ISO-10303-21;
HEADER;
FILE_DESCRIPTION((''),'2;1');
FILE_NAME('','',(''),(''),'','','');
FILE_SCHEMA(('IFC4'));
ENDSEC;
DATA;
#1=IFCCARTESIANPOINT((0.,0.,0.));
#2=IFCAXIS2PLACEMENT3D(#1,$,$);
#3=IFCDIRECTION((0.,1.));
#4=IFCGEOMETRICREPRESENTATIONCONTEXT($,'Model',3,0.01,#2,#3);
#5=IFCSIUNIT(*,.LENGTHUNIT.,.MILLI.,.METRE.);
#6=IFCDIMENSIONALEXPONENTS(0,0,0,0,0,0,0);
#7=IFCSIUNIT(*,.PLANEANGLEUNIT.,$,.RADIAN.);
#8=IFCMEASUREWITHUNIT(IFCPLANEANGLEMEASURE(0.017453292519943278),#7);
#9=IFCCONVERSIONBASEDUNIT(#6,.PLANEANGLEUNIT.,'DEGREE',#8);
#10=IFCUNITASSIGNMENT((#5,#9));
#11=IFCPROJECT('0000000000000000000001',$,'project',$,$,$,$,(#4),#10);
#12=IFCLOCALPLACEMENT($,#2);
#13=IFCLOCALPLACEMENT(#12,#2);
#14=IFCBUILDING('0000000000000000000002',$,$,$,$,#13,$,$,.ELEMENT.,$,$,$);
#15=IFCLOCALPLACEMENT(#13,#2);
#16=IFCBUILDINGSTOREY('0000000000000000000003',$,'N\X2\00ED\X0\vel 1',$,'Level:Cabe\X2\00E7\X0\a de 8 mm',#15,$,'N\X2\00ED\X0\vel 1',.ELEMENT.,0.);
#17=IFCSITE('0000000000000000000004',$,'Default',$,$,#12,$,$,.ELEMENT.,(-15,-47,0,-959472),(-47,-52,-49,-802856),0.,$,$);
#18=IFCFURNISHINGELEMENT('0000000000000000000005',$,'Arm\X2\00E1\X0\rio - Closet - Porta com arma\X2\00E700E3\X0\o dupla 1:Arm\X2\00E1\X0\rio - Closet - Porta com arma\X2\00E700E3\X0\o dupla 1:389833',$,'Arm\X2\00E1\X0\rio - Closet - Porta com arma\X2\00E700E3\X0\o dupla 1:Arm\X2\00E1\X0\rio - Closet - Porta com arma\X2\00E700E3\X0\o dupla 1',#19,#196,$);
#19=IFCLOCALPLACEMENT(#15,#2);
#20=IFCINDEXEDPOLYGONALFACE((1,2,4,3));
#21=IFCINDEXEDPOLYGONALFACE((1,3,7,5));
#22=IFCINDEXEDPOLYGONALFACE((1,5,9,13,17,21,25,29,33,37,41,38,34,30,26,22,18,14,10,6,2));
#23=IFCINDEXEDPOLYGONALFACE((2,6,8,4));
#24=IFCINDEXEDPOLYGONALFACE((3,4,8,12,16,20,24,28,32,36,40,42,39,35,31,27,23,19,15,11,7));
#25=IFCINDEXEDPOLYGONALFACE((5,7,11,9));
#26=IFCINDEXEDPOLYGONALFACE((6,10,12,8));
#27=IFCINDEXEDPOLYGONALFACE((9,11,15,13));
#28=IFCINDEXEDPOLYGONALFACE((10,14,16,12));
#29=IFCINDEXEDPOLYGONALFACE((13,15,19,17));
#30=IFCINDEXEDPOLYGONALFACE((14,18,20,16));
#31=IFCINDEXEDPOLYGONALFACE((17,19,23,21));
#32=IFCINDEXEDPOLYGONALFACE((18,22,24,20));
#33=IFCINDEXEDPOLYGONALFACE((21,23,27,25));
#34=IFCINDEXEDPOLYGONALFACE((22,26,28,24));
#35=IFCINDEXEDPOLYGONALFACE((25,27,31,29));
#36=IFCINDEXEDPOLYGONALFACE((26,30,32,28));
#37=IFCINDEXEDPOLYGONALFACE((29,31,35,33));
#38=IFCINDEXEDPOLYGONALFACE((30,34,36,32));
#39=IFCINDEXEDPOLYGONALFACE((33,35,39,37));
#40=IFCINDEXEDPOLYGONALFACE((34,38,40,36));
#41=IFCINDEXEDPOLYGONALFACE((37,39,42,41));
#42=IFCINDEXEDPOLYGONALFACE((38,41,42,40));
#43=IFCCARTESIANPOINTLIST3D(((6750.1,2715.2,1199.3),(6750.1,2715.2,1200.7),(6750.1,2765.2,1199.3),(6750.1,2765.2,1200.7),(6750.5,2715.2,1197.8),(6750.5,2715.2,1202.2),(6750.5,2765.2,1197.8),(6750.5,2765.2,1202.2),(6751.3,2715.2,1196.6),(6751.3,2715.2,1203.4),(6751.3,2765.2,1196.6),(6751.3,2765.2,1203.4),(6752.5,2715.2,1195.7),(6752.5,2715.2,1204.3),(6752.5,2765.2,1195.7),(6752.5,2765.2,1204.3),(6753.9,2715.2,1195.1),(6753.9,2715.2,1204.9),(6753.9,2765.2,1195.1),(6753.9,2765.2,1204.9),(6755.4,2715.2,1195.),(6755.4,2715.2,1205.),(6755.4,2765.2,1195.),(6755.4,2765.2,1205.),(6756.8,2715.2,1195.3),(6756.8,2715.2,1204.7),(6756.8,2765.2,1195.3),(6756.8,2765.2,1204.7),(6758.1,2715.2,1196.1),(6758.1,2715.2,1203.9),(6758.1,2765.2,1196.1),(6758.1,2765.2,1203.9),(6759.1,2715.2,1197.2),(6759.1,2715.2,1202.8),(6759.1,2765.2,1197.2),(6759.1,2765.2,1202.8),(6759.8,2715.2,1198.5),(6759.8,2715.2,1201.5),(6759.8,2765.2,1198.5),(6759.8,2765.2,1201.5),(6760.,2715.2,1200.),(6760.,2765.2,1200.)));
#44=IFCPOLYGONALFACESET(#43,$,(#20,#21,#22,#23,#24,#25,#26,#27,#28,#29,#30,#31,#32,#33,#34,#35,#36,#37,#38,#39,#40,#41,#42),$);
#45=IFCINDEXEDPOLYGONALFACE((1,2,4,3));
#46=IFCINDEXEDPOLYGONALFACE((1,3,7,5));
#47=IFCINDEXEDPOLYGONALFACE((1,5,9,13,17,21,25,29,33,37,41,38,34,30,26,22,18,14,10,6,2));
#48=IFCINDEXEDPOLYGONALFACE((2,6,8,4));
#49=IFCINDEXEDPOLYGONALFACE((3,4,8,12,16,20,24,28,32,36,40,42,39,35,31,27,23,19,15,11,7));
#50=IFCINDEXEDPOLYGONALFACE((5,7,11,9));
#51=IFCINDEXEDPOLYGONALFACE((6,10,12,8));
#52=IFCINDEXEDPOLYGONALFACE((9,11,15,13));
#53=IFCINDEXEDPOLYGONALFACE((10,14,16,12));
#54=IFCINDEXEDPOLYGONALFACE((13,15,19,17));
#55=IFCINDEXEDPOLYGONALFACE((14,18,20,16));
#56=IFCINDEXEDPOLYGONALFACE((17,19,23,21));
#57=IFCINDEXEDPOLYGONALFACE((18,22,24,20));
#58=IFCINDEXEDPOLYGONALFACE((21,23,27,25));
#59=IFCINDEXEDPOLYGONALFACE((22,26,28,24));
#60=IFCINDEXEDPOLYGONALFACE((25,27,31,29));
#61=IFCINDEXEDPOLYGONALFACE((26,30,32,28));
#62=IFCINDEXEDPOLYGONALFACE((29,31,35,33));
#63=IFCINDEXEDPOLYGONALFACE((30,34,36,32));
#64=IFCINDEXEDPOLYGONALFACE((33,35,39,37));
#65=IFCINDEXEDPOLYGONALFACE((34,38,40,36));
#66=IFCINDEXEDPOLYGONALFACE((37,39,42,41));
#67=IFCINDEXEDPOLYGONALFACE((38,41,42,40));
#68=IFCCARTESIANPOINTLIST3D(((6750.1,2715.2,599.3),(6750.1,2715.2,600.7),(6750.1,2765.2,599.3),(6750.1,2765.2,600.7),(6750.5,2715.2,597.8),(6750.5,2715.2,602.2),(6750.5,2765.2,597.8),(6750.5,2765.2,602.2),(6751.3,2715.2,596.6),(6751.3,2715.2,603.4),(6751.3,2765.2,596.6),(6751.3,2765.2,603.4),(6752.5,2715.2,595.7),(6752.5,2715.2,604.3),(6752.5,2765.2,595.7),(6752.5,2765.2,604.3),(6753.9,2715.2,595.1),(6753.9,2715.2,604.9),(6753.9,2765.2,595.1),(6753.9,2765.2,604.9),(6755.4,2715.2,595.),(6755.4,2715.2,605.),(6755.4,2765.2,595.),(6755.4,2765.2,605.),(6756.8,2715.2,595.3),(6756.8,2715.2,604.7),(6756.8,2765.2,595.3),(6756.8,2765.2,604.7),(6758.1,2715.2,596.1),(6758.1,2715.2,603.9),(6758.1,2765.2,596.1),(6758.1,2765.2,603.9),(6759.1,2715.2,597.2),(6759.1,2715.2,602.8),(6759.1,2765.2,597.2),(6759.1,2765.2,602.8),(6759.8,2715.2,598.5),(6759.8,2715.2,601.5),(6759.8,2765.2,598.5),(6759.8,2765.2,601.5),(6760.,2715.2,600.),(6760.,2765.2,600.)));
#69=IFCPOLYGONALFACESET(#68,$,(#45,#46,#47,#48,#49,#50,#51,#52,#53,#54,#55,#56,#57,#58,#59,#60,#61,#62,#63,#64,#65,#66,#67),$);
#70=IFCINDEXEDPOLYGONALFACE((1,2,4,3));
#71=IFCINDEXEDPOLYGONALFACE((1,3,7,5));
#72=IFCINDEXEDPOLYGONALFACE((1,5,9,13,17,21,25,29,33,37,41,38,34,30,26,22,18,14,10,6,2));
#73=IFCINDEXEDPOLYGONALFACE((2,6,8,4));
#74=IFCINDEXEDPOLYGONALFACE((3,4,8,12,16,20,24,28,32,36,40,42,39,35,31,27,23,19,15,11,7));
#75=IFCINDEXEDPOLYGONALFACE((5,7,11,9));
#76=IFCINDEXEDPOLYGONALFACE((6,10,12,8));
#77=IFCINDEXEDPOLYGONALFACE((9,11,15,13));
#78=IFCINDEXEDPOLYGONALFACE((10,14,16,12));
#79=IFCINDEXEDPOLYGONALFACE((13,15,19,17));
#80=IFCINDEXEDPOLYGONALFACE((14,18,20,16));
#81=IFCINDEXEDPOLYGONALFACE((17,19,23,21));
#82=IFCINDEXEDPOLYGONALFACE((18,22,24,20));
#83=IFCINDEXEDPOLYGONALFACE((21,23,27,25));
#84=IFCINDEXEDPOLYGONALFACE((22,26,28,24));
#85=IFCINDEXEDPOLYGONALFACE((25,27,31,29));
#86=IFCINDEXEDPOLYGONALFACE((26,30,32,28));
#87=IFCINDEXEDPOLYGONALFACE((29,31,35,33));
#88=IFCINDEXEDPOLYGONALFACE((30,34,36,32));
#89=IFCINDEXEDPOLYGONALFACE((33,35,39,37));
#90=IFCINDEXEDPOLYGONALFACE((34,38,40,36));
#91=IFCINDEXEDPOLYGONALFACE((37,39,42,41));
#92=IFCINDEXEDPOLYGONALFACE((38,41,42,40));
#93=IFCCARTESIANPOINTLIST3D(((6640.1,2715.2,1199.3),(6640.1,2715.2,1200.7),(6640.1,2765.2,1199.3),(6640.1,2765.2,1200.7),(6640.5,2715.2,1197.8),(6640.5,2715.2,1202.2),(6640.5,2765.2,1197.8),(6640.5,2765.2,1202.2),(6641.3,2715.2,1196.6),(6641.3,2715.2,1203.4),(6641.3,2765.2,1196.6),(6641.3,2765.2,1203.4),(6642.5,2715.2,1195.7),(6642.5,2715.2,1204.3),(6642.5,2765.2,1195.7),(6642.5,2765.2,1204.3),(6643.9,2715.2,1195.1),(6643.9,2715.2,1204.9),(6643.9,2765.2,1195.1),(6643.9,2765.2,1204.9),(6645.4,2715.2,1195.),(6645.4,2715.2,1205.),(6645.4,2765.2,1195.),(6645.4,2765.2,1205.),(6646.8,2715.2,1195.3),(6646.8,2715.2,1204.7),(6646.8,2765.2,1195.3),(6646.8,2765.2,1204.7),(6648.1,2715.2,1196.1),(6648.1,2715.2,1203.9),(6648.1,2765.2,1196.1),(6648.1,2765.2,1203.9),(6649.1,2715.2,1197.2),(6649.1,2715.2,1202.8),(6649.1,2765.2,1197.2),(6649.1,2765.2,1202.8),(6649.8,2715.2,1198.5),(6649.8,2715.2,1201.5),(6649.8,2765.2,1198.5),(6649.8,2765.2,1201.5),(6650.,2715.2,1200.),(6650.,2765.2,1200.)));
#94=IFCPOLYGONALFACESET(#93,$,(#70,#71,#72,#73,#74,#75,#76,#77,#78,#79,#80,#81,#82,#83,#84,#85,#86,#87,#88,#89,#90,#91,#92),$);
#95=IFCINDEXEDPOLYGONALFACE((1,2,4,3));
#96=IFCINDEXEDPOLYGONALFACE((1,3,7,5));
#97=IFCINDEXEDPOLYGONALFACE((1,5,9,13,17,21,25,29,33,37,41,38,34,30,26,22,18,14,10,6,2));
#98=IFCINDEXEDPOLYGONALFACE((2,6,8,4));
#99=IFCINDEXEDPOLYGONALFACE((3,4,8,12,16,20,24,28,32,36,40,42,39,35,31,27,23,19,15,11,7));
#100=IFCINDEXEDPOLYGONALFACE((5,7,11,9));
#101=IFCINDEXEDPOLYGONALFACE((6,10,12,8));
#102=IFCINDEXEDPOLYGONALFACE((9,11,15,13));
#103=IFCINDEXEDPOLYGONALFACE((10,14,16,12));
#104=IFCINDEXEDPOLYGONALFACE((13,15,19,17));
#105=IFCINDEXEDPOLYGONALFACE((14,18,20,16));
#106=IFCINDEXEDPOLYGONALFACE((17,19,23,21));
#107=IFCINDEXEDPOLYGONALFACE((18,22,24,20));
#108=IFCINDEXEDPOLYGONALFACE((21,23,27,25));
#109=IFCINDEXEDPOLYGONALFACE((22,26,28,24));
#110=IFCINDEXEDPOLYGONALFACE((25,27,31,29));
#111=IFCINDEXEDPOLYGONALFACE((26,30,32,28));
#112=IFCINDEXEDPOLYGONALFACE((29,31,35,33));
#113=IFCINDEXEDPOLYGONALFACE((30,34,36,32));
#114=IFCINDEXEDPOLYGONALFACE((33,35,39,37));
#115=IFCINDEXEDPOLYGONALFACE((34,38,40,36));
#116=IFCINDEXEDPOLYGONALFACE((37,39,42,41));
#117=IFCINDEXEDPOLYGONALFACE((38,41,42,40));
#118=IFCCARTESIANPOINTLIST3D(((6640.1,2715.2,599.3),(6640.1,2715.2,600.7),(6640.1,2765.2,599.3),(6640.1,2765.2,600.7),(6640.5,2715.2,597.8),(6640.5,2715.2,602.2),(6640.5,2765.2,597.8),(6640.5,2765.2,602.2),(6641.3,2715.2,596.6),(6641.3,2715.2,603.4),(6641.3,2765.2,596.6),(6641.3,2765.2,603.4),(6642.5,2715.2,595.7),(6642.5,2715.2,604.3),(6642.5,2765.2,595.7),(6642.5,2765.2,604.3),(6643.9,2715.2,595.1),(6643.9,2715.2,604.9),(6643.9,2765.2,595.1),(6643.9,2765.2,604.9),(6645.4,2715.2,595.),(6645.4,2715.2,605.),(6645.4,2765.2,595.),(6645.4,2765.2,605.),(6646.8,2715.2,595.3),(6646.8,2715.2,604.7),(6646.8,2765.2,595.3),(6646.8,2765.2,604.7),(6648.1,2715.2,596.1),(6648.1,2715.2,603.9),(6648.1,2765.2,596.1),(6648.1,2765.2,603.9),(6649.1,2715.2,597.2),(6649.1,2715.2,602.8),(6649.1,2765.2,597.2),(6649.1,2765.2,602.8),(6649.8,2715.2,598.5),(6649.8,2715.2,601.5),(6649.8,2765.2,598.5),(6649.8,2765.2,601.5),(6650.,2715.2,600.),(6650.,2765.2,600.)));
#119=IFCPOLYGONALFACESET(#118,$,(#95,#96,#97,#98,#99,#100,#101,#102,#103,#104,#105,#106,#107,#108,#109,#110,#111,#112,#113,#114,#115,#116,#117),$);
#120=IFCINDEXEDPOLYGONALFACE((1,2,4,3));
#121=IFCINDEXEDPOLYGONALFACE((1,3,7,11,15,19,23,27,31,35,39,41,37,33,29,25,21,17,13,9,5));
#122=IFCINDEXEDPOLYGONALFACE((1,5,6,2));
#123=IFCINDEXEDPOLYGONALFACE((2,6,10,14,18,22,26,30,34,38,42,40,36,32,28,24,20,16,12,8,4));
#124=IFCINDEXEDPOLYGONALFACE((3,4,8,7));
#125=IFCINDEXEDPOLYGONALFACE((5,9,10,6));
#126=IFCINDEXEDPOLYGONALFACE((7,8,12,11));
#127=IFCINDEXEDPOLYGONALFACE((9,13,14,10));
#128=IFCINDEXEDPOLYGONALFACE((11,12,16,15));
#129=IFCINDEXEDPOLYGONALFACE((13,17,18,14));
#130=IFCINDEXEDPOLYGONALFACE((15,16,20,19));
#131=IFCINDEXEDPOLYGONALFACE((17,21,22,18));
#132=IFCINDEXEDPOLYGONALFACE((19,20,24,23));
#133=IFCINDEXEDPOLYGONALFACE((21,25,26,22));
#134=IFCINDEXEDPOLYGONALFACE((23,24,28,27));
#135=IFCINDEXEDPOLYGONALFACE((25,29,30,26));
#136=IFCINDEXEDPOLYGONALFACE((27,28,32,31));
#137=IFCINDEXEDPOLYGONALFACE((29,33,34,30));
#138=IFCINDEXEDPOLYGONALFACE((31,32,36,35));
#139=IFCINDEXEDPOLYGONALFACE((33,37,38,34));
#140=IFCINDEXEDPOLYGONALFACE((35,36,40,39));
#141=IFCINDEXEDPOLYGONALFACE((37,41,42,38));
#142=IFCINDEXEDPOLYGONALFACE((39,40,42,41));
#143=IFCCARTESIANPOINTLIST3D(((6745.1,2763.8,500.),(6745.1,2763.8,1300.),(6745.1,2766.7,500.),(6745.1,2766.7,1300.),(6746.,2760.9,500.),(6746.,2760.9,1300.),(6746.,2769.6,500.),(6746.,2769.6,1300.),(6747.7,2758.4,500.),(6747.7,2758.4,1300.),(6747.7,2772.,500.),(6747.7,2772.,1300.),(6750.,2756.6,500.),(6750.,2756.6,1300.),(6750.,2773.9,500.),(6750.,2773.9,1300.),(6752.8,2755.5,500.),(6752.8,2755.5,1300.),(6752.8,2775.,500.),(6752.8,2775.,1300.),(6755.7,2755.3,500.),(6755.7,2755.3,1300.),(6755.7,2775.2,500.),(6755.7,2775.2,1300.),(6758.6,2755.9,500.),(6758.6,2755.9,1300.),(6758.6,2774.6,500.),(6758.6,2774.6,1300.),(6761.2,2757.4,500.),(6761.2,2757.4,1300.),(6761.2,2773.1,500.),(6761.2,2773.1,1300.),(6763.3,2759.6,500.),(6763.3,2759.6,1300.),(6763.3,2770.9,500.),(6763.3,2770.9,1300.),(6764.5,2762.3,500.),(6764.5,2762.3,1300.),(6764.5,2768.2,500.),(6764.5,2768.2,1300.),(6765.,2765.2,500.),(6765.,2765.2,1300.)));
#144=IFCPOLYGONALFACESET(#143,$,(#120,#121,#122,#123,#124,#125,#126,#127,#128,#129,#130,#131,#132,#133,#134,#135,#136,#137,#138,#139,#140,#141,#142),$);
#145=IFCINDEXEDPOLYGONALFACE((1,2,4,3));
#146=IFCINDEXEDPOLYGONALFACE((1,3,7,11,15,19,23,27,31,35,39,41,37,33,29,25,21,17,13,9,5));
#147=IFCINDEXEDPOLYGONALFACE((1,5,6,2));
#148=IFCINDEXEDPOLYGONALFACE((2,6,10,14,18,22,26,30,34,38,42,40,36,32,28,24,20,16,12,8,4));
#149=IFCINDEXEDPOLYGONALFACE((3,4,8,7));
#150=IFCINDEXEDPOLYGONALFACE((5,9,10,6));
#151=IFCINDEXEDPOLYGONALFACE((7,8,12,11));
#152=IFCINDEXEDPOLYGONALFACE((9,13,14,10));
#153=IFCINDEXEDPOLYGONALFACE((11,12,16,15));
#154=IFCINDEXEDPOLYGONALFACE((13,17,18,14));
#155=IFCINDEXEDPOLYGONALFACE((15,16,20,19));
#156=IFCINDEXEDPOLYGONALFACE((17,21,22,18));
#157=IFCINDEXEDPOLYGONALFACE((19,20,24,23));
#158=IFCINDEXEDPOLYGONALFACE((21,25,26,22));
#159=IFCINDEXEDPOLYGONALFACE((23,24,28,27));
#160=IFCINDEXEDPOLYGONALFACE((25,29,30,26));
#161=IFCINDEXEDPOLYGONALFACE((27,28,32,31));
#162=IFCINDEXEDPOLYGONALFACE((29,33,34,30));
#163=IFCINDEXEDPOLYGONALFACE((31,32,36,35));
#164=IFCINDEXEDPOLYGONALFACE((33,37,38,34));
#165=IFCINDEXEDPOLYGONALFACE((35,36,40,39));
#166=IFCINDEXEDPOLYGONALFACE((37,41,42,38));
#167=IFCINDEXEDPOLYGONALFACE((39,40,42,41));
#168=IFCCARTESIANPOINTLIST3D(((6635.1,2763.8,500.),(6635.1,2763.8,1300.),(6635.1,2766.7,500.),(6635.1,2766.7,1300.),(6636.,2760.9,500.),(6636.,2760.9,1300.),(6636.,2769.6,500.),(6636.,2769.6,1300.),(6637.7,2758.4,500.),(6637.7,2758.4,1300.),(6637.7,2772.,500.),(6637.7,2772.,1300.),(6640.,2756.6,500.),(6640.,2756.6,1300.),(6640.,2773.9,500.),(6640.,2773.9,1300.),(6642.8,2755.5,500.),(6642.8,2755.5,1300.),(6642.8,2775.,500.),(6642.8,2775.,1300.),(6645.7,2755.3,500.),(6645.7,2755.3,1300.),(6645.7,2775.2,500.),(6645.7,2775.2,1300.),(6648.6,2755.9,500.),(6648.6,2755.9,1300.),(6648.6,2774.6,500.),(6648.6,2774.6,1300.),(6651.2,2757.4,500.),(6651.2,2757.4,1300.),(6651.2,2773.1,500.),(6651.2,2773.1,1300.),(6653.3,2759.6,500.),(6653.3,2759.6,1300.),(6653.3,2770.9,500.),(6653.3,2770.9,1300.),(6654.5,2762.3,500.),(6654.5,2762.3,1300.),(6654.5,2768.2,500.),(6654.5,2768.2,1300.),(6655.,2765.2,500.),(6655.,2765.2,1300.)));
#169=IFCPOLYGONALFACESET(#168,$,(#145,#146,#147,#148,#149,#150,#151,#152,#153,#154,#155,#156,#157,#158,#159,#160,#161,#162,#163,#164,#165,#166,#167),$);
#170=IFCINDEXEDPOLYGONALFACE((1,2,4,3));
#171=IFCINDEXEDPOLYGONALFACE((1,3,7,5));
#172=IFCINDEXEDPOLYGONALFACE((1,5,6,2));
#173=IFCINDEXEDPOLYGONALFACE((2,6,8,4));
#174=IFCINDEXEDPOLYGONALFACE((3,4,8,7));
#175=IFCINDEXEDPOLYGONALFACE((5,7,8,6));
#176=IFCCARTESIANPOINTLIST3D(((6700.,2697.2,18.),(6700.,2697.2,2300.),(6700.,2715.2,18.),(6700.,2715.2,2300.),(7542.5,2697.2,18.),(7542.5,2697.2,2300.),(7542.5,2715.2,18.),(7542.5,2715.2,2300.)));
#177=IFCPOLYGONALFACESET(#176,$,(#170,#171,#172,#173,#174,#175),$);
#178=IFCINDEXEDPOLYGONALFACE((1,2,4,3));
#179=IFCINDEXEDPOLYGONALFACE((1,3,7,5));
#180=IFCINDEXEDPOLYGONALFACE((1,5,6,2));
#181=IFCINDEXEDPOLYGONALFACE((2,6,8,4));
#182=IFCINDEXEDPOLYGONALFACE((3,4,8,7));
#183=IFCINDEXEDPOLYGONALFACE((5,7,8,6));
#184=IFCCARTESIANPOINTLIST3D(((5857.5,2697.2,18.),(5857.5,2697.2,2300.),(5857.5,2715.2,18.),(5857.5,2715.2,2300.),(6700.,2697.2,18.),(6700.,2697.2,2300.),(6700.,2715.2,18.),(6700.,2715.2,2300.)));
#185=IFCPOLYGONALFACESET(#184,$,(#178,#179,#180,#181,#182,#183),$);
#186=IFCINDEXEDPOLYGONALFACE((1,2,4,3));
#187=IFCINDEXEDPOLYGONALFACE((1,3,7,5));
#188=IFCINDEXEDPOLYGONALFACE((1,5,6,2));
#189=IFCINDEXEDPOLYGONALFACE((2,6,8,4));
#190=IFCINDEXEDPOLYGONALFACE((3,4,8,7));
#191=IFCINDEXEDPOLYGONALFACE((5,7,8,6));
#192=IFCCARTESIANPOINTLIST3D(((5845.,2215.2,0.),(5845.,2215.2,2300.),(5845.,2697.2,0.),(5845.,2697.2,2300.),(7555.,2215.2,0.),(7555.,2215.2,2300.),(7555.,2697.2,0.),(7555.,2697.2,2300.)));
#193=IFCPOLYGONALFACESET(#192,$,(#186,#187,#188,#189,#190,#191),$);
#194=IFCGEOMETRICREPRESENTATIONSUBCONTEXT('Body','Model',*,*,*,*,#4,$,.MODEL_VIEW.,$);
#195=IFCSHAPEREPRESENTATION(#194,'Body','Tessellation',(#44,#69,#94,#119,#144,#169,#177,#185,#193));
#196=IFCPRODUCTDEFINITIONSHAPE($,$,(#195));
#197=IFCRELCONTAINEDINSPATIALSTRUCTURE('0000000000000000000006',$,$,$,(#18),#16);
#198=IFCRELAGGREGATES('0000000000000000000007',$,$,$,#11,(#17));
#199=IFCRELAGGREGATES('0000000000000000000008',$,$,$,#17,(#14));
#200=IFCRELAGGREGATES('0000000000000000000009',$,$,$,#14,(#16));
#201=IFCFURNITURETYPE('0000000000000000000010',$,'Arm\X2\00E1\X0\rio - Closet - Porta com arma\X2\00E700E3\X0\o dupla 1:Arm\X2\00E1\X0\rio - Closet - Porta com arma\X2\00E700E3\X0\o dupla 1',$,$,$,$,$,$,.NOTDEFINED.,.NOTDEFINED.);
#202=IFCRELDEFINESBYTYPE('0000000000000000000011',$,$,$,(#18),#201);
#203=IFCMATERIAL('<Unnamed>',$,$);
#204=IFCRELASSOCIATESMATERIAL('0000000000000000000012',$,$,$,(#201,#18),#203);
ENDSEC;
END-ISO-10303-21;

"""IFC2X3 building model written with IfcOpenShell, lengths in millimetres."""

from ifc_helpers import new_model, entity, si_unit, converted_unit, direction, frame, origin, origin_2d_with_axis, place, context, subcontext, project, spatial, rectangle, circle, extrude, source, transform, mapped, material, type_object, type_shapes, element, save


model = new_model("IFC2X3")

# Units and contexts
model_context = context("Model", 3, precision=0.01, world=origin(), true_north=direction((0.0, 1.0)))
body_context = subcontext(model_context, "Body", "Model", "MODEL_VIEW")
ifc_project = project(units=[si_unit("LENGTHUNIT", "METRE", prefix="MILLI"), converted_unit("PLANEANGLEUNIT", "DEGREE", entity("IfcPlaneAngleMeasure", 0.017453292519943278), si_unit("PLANEANGLEUNIT", "RADIAN"), dimensions=[0, 0, 0, 0, 0, 0, 0])], contexts=[model_context])

# Site, building, storey
site_placement = place(None, origin())
site = spatial("IfcSite", under=ifc_project, at=site_placement, Name="Default", CompositionType="ELEMENT", RefLatitude=(-15, -47, 0, -959472), RefLongitude=(-47, -52, -49, -802856), RefElevation=0.0)
building_placement = place(site_placement, origin())
building = spatial("IfcBuilding", under=site, at=building_placement, CompositionType="ELEMENT")
storey_placement = place(building_placement, origin())
storey = spatial("IfcBuildingStorey", under=building, at=storey_placement, Name="Nível 1", ObjectType="Level:Cabeça de 8 mm", LongName="Nível 1", CompositionType="ELEMENT", Elevation=0.0)

# Furnishing element
ifc_material_1 = material(Name="<Unnamed>")
furniture_type_1 = type_object("IfcFurnitureType", Name="Armário - Closet - Porta com armação dupla 1:Armário - Closet - Porta com armação dupla 1", AssemblyPlace="NOTDEFINED", material=ifc_material_1)
shared_shape_1 = source(origin(), body_context, "Body", "SweptSolid", [
    extrude(circle(Radius=5.0, at=origin_2d_with_axis()), frame((55.0, 500.0, 1200.0), z_axis=(0.0, 1.0, 0.0), x_axis=(1.0, 0.0, 0.0)), (0.0, 0.0, 1.0), 50.0),
    extrude(circle(Radius=5.0, at=origin_2d_with_axis()), frame((55.0, 500.0, 600.0), z_axis=(0.0, 1.0, 0.0), x_axis=(1.0, 0.0, 0.0)), (0.0, 0.0, 1.0), 50.0),
    extrude(circle(Radius=5.0, at=origin_2d_with_axis()), frame((-55.0, 500.0, 1200.0), z_axis=(0.0, 1.0, 0.0), x_axis=(1.0, 0.0, 0.0)), (0.0, 0.0, 1.0), 50.0),
    extrude(circle(Radius=5.0, at=origin_2d_with_axis()), frame((-55.0, 500.0, 600.0), z_axis=(0.0, 1.0, 0.0), x_axis=(1.0, 0.0, 0.0)), (0.0, 0.0, 1.0), 50.0),
    extrude(circle(Radius=10.0, at=origin_2d_with_axis()), frame((55.0, 550.0, 500.0)), (0.0, 0.0, 1.0), 800.0),
    extrude(circle(Radius=10.0, at=origin_2d_with_axis()), frame((-55.0, 550.0, 500.0)), (0.0, 0.0, 1.0), 800.0),
    extrude(rectangle(XDim=842.5, YDim=18.0, at=origin_2d_with_axis()), frame((421.3, 491.0, 18.0)), (0.0, 0.0, 1.0), 2282.0),
    extrude(rectangle(XDim=18.0, YDim=842.5, at=origin_2d_with_axis()), frame((-421.3, 491.0, 18.0), z_axis=(0.0, 0.0, 1.0), x_axis=(0.0, 1.0, 0.0)), (0.0, 0.0, 1.0), 2282.0),
    extrude(rectangle(XDim=482.0, YDim=1710.0, at=origin_2d_with_axis()), frame((0.0, 241.0, 0.0), z_axis=(0.0, 0.0, 1.0), x_axis=(0.0, 1.0, 0.0)), (0.0, 0.0, 1.0), 2300.0),
])
type_shapes(furniture_type_1, [shared_shape_1])
furnishing_1_placement = place(storey_placement, frame((6700.0, 2215.2, 0.0)))
element("IfcFurnishingElement", 1, at=furnishing_1_placement, inside=storey, type_object=furniture_type_1, material=ifc_material_1, Name="Armário - Closet - Porta com armação dupla 1:Armário - Closet - Porta com armação dupla 1:389833", ObjectType="Armário - Closet - Porta com armação dupla 1:Armário - Closet - Porta com armação dupla 1", context=body_context, shape_type="MappedRepresentation", body=[
    mapped(shared_shape_1, transform((0.0, 0.0, 0.0), scale=1.0)),
])

save(model, "model.ifc")
